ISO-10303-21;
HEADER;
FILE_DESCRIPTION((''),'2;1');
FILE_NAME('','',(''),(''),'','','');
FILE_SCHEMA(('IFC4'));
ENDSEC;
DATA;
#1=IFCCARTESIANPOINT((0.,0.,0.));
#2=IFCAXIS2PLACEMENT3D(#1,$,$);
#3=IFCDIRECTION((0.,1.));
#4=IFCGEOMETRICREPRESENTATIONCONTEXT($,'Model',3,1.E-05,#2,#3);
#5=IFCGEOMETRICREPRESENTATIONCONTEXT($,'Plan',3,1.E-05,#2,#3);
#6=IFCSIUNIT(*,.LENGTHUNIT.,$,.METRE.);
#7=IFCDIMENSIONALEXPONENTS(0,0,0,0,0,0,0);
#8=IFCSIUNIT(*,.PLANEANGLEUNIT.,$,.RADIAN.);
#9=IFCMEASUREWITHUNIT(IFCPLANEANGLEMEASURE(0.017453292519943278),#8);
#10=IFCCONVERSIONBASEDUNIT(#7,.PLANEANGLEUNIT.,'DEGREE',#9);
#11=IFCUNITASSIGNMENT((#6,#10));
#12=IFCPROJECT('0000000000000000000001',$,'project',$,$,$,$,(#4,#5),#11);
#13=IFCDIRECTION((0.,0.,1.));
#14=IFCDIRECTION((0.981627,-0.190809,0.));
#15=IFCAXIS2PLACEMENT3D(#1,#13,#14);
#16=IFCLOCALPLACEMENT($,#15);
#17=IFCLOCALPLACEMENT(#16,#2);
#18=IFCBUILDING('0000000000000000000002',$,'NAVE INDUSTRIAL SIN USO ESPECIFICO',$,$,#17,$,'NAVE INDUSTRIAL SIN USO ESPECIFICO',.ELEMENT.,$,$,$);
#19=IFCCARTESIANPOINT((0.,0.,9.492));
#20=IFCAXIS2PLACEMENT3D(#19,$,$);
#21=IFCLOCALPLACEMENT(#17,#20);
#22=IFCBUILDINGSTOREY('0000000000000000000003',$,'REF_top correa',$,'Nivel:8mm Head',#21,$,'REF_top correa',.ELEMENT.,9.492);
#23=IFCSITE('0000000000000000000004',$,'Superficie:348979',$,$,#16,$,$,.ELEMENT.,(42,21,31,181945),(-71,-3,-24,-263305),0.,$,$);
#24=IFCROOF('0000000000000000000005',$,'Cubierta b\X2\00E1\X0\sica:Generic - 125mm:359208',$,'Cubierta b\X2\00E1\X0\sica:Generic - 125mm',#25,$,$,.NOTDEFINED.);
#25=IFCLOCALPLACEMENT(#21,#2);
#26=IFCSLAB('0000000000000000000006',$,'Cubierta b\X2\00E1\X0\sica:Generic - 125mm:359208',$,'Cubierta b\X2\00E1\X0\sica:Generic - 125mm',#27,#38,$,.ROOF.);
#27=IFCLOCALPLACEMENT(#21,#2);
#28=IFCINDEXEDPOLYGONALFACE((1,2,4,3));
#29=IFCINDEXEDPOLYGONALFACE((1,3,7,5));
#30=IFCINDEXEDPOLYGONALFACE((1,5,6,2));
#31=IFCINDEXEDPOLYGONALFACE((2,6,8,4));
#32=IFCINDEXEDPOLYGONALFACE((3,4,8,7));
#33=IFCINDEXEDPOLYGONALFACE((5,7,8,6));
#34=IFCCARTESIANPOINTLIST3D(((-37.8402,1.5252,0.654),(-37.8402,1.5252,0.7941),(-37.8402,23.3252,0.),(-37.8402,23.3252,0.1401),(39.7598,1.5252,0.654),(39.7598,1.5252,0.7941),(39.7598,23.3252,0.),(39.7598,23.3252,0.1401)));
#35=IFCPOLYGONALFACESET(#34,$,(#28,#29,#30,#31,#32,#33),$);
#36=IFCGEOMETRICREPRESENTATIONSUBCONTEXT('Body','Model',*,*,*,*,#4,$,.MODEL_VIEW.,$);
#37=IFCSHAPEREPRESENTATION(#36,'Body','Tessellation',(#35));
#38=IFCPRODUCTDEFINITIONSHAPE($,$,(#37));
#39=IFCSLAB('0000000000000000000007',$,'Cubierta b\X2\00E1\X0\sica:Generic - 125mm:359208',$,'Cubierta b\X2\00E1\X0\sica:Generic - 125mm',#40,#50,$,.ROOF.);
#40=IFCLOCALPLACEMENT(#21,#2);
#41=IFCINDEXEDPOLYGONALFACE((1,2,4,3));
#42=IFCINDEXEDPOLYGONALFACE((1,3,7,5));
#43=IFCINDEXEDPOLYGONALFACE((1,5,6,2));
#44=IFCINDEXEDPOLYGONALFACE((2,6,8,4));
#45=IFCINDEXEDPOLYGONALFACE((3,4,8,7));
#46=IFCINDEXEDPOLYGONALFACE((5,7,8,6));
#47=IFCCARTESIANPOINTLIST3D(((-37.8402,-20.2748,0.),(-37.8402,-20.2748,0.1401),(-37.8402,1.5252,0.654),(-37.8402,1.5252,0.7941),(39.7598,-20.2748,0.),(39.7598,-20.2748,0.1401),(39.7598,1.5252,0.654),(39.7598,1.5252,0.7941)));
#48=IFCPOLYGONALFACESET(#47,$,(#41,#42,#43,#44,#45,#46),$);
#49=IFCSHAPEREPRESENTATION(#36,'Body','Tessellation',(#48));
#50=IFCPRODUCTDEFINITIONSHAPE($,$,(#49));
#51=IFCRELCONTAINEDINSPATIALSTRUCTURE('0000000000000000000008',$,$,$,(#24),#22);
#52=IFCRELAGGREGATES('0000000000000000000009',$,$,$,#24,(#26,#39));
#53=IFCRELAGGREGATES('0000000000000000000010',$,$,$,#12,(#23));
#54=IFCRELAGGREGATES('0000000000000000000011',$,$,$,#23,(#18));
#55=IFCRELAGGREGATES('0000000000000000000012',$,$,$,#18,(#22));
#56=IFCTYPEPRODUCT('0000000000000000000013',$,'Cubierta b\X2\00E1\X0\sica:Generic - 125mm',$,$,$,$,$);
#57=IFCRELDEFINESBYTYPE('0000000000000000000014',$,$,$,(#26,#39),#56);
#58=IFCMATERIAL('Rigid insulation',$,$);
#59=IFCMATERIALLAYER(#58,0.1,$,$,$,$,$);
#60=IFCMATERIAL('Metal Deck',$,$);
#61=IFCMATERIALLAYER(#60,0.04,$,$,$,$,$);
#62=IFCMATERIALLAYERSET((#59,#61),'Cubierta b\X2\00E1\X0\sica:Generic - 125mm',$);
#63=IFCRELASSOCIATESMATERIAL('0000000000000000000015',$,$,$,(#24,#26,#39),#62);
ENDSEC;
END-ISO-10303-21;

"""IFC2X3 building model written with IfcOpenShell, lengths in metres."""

from ifc_helpers import new_model, entity, si_unit, converted_unit, direction, frame, frame_2d, origin, place, context, subcontext, project, spatial, rectangle, extrude, material, layer, layer_set, type_object, element, aggregate, save


model = new_model("IFC2X3")

# Units and contexts
model_context = context("Model", 3, precision=1e-05, world=origin(), true_north=direction((0.0, 1.0)))
plan_context = context("Plan", 3, precision=1e-05, world=origin(), true_north=direction((0.0, 1.0)))
body_context = subcontext(model_context, "Body", "Model", "MODEL_VIEW")
ifc_project = project(units=[si_unit("LENGTHUNIT", "METRE"), converted_unit("PLANEANGLEUNIT", "DEGREE", entity("IfcPlaneAngleMeasure", 0.017453292519943278), si_unit("PLANEANGLEUNIT", "RADIAN"), dimensions=[0, 0, 0, 0, 0, 0, 0])], contexts=[model_context, plan_context])

# Site, building, storey
site_placement = place(None, frame((0.0, 0.0, 0.0), z_axis=(0.0, 0.0, 1.0), x_axis=(0.981627, -0.190809, 0.0)))
site = spatial("IfcSite", under=ifc_project, at=site_placement, Name="Superficie:348979", CompositionType="ELEMENT", RefLatitude=(42, 21, 31, 181945), RefLongitude=(-71, -3, -24, -263305), RefElevation=0.0)
building_placement = place(site_placement, origin())
building = spatial("IfcBuilding", under=site, at=building_placement, Name="NAVE INDUSTRIAL SIN USO ESPECIFICO", LongName="NAVE INDUSTRIAL SIN USO ESPECIFICO", CompositionType="ELEMENT")
storey_placement = place(building_placement, frame((0.0, 0.0, 9.492)))
storey = spatial("IfcBuildingStorey", under=building, at=storey_placement, Name="REF_top correa", ObjectType="Nivel:8mm Head", LongName="REF_top correa", CompositionType="ELEMENT", Elevation=9.492)

# Roof, slabs
ifc_material_1 = material(Name="Rigid insulation")
ifc_layer_1 = layer(ifc_material_1, 0.1)
ifc_material_2 = material(Name="Metal Deck")
ifc_layer_2 = layer(ifc_material_2, 0.04)
ifc_layer_set = layer_set([ifc_layer_1, ifc_layer_2], Name="Cubierta básica:Generic - 125mm")
roof_placement = place(storey_placement, frame((-37.8402, -20.2748, 0.0)))
roof = element("IfcRoof", 1, at=roof_placement, inside=storey, material=ifc_layer_set, Name="Cubierta básica:Generic - 125mm:359208", ObjectType="Cubierta básica:Generic - 125mm", ShapeType="NOTDEFINED")
type_product = type_object("IfcTypeProduct", Name="Cubierta básica:Generic - 125mm")
slab_1_placement = place(roof_placement, origin())
slab_1 = element("IfcSlab", 2, at=slab_1_placement, type_object=type_product, material=ifc_layer_set, Name="Cubierta básica:Generic - 125mm:359208", ObjectType="Cubierta básica:Generic - 125mm", PredefinedType="ROOF", context=body_context, shape_type="SweptSolid", body=[
    extrude(rectangle(XDim=77.6, YDim=21.8098, at=frame_2d((0.0, 0.0), x_axis=(1.0, 0.0))), frame((38.8, 32.7, 0.327), z_axis=(0.0, 0.029987, 0.99955), x_axis=(1.0, 0.0, 0.0)), (0.0, -0.029987, 0.99955), 0.1401),
])
slab_2_placement = place(roof_placement, origin())
slab_2 = element("IfcSlab", 3, at=slab_2_placement, type_object=type_product, material=ifc_layer_set, Name="Cubierta básica:Generic - 125mm:359208", ObjectType="Cubierta básica:Generic - 125mm", PredefinedType="ROOF", context=body_context, shape_type="SweptSolid", body=[
    extrude(rectangle(XDim=21.8098, YDim=77.6, at=frame_2d((0.0, 0.0), x_axis=(0.0, 1.0))), frame((38.8, 10.9, 0.327), z_axis=(0.0, -0.029987, 0.99955), x_axis=(1.0, 0.0, 0.0)), (0.0, 0.029987, 0.99955), 0.1401),
])
aggregate(roof, [slab_1, slab_2])

save(model, "model.ifc")
